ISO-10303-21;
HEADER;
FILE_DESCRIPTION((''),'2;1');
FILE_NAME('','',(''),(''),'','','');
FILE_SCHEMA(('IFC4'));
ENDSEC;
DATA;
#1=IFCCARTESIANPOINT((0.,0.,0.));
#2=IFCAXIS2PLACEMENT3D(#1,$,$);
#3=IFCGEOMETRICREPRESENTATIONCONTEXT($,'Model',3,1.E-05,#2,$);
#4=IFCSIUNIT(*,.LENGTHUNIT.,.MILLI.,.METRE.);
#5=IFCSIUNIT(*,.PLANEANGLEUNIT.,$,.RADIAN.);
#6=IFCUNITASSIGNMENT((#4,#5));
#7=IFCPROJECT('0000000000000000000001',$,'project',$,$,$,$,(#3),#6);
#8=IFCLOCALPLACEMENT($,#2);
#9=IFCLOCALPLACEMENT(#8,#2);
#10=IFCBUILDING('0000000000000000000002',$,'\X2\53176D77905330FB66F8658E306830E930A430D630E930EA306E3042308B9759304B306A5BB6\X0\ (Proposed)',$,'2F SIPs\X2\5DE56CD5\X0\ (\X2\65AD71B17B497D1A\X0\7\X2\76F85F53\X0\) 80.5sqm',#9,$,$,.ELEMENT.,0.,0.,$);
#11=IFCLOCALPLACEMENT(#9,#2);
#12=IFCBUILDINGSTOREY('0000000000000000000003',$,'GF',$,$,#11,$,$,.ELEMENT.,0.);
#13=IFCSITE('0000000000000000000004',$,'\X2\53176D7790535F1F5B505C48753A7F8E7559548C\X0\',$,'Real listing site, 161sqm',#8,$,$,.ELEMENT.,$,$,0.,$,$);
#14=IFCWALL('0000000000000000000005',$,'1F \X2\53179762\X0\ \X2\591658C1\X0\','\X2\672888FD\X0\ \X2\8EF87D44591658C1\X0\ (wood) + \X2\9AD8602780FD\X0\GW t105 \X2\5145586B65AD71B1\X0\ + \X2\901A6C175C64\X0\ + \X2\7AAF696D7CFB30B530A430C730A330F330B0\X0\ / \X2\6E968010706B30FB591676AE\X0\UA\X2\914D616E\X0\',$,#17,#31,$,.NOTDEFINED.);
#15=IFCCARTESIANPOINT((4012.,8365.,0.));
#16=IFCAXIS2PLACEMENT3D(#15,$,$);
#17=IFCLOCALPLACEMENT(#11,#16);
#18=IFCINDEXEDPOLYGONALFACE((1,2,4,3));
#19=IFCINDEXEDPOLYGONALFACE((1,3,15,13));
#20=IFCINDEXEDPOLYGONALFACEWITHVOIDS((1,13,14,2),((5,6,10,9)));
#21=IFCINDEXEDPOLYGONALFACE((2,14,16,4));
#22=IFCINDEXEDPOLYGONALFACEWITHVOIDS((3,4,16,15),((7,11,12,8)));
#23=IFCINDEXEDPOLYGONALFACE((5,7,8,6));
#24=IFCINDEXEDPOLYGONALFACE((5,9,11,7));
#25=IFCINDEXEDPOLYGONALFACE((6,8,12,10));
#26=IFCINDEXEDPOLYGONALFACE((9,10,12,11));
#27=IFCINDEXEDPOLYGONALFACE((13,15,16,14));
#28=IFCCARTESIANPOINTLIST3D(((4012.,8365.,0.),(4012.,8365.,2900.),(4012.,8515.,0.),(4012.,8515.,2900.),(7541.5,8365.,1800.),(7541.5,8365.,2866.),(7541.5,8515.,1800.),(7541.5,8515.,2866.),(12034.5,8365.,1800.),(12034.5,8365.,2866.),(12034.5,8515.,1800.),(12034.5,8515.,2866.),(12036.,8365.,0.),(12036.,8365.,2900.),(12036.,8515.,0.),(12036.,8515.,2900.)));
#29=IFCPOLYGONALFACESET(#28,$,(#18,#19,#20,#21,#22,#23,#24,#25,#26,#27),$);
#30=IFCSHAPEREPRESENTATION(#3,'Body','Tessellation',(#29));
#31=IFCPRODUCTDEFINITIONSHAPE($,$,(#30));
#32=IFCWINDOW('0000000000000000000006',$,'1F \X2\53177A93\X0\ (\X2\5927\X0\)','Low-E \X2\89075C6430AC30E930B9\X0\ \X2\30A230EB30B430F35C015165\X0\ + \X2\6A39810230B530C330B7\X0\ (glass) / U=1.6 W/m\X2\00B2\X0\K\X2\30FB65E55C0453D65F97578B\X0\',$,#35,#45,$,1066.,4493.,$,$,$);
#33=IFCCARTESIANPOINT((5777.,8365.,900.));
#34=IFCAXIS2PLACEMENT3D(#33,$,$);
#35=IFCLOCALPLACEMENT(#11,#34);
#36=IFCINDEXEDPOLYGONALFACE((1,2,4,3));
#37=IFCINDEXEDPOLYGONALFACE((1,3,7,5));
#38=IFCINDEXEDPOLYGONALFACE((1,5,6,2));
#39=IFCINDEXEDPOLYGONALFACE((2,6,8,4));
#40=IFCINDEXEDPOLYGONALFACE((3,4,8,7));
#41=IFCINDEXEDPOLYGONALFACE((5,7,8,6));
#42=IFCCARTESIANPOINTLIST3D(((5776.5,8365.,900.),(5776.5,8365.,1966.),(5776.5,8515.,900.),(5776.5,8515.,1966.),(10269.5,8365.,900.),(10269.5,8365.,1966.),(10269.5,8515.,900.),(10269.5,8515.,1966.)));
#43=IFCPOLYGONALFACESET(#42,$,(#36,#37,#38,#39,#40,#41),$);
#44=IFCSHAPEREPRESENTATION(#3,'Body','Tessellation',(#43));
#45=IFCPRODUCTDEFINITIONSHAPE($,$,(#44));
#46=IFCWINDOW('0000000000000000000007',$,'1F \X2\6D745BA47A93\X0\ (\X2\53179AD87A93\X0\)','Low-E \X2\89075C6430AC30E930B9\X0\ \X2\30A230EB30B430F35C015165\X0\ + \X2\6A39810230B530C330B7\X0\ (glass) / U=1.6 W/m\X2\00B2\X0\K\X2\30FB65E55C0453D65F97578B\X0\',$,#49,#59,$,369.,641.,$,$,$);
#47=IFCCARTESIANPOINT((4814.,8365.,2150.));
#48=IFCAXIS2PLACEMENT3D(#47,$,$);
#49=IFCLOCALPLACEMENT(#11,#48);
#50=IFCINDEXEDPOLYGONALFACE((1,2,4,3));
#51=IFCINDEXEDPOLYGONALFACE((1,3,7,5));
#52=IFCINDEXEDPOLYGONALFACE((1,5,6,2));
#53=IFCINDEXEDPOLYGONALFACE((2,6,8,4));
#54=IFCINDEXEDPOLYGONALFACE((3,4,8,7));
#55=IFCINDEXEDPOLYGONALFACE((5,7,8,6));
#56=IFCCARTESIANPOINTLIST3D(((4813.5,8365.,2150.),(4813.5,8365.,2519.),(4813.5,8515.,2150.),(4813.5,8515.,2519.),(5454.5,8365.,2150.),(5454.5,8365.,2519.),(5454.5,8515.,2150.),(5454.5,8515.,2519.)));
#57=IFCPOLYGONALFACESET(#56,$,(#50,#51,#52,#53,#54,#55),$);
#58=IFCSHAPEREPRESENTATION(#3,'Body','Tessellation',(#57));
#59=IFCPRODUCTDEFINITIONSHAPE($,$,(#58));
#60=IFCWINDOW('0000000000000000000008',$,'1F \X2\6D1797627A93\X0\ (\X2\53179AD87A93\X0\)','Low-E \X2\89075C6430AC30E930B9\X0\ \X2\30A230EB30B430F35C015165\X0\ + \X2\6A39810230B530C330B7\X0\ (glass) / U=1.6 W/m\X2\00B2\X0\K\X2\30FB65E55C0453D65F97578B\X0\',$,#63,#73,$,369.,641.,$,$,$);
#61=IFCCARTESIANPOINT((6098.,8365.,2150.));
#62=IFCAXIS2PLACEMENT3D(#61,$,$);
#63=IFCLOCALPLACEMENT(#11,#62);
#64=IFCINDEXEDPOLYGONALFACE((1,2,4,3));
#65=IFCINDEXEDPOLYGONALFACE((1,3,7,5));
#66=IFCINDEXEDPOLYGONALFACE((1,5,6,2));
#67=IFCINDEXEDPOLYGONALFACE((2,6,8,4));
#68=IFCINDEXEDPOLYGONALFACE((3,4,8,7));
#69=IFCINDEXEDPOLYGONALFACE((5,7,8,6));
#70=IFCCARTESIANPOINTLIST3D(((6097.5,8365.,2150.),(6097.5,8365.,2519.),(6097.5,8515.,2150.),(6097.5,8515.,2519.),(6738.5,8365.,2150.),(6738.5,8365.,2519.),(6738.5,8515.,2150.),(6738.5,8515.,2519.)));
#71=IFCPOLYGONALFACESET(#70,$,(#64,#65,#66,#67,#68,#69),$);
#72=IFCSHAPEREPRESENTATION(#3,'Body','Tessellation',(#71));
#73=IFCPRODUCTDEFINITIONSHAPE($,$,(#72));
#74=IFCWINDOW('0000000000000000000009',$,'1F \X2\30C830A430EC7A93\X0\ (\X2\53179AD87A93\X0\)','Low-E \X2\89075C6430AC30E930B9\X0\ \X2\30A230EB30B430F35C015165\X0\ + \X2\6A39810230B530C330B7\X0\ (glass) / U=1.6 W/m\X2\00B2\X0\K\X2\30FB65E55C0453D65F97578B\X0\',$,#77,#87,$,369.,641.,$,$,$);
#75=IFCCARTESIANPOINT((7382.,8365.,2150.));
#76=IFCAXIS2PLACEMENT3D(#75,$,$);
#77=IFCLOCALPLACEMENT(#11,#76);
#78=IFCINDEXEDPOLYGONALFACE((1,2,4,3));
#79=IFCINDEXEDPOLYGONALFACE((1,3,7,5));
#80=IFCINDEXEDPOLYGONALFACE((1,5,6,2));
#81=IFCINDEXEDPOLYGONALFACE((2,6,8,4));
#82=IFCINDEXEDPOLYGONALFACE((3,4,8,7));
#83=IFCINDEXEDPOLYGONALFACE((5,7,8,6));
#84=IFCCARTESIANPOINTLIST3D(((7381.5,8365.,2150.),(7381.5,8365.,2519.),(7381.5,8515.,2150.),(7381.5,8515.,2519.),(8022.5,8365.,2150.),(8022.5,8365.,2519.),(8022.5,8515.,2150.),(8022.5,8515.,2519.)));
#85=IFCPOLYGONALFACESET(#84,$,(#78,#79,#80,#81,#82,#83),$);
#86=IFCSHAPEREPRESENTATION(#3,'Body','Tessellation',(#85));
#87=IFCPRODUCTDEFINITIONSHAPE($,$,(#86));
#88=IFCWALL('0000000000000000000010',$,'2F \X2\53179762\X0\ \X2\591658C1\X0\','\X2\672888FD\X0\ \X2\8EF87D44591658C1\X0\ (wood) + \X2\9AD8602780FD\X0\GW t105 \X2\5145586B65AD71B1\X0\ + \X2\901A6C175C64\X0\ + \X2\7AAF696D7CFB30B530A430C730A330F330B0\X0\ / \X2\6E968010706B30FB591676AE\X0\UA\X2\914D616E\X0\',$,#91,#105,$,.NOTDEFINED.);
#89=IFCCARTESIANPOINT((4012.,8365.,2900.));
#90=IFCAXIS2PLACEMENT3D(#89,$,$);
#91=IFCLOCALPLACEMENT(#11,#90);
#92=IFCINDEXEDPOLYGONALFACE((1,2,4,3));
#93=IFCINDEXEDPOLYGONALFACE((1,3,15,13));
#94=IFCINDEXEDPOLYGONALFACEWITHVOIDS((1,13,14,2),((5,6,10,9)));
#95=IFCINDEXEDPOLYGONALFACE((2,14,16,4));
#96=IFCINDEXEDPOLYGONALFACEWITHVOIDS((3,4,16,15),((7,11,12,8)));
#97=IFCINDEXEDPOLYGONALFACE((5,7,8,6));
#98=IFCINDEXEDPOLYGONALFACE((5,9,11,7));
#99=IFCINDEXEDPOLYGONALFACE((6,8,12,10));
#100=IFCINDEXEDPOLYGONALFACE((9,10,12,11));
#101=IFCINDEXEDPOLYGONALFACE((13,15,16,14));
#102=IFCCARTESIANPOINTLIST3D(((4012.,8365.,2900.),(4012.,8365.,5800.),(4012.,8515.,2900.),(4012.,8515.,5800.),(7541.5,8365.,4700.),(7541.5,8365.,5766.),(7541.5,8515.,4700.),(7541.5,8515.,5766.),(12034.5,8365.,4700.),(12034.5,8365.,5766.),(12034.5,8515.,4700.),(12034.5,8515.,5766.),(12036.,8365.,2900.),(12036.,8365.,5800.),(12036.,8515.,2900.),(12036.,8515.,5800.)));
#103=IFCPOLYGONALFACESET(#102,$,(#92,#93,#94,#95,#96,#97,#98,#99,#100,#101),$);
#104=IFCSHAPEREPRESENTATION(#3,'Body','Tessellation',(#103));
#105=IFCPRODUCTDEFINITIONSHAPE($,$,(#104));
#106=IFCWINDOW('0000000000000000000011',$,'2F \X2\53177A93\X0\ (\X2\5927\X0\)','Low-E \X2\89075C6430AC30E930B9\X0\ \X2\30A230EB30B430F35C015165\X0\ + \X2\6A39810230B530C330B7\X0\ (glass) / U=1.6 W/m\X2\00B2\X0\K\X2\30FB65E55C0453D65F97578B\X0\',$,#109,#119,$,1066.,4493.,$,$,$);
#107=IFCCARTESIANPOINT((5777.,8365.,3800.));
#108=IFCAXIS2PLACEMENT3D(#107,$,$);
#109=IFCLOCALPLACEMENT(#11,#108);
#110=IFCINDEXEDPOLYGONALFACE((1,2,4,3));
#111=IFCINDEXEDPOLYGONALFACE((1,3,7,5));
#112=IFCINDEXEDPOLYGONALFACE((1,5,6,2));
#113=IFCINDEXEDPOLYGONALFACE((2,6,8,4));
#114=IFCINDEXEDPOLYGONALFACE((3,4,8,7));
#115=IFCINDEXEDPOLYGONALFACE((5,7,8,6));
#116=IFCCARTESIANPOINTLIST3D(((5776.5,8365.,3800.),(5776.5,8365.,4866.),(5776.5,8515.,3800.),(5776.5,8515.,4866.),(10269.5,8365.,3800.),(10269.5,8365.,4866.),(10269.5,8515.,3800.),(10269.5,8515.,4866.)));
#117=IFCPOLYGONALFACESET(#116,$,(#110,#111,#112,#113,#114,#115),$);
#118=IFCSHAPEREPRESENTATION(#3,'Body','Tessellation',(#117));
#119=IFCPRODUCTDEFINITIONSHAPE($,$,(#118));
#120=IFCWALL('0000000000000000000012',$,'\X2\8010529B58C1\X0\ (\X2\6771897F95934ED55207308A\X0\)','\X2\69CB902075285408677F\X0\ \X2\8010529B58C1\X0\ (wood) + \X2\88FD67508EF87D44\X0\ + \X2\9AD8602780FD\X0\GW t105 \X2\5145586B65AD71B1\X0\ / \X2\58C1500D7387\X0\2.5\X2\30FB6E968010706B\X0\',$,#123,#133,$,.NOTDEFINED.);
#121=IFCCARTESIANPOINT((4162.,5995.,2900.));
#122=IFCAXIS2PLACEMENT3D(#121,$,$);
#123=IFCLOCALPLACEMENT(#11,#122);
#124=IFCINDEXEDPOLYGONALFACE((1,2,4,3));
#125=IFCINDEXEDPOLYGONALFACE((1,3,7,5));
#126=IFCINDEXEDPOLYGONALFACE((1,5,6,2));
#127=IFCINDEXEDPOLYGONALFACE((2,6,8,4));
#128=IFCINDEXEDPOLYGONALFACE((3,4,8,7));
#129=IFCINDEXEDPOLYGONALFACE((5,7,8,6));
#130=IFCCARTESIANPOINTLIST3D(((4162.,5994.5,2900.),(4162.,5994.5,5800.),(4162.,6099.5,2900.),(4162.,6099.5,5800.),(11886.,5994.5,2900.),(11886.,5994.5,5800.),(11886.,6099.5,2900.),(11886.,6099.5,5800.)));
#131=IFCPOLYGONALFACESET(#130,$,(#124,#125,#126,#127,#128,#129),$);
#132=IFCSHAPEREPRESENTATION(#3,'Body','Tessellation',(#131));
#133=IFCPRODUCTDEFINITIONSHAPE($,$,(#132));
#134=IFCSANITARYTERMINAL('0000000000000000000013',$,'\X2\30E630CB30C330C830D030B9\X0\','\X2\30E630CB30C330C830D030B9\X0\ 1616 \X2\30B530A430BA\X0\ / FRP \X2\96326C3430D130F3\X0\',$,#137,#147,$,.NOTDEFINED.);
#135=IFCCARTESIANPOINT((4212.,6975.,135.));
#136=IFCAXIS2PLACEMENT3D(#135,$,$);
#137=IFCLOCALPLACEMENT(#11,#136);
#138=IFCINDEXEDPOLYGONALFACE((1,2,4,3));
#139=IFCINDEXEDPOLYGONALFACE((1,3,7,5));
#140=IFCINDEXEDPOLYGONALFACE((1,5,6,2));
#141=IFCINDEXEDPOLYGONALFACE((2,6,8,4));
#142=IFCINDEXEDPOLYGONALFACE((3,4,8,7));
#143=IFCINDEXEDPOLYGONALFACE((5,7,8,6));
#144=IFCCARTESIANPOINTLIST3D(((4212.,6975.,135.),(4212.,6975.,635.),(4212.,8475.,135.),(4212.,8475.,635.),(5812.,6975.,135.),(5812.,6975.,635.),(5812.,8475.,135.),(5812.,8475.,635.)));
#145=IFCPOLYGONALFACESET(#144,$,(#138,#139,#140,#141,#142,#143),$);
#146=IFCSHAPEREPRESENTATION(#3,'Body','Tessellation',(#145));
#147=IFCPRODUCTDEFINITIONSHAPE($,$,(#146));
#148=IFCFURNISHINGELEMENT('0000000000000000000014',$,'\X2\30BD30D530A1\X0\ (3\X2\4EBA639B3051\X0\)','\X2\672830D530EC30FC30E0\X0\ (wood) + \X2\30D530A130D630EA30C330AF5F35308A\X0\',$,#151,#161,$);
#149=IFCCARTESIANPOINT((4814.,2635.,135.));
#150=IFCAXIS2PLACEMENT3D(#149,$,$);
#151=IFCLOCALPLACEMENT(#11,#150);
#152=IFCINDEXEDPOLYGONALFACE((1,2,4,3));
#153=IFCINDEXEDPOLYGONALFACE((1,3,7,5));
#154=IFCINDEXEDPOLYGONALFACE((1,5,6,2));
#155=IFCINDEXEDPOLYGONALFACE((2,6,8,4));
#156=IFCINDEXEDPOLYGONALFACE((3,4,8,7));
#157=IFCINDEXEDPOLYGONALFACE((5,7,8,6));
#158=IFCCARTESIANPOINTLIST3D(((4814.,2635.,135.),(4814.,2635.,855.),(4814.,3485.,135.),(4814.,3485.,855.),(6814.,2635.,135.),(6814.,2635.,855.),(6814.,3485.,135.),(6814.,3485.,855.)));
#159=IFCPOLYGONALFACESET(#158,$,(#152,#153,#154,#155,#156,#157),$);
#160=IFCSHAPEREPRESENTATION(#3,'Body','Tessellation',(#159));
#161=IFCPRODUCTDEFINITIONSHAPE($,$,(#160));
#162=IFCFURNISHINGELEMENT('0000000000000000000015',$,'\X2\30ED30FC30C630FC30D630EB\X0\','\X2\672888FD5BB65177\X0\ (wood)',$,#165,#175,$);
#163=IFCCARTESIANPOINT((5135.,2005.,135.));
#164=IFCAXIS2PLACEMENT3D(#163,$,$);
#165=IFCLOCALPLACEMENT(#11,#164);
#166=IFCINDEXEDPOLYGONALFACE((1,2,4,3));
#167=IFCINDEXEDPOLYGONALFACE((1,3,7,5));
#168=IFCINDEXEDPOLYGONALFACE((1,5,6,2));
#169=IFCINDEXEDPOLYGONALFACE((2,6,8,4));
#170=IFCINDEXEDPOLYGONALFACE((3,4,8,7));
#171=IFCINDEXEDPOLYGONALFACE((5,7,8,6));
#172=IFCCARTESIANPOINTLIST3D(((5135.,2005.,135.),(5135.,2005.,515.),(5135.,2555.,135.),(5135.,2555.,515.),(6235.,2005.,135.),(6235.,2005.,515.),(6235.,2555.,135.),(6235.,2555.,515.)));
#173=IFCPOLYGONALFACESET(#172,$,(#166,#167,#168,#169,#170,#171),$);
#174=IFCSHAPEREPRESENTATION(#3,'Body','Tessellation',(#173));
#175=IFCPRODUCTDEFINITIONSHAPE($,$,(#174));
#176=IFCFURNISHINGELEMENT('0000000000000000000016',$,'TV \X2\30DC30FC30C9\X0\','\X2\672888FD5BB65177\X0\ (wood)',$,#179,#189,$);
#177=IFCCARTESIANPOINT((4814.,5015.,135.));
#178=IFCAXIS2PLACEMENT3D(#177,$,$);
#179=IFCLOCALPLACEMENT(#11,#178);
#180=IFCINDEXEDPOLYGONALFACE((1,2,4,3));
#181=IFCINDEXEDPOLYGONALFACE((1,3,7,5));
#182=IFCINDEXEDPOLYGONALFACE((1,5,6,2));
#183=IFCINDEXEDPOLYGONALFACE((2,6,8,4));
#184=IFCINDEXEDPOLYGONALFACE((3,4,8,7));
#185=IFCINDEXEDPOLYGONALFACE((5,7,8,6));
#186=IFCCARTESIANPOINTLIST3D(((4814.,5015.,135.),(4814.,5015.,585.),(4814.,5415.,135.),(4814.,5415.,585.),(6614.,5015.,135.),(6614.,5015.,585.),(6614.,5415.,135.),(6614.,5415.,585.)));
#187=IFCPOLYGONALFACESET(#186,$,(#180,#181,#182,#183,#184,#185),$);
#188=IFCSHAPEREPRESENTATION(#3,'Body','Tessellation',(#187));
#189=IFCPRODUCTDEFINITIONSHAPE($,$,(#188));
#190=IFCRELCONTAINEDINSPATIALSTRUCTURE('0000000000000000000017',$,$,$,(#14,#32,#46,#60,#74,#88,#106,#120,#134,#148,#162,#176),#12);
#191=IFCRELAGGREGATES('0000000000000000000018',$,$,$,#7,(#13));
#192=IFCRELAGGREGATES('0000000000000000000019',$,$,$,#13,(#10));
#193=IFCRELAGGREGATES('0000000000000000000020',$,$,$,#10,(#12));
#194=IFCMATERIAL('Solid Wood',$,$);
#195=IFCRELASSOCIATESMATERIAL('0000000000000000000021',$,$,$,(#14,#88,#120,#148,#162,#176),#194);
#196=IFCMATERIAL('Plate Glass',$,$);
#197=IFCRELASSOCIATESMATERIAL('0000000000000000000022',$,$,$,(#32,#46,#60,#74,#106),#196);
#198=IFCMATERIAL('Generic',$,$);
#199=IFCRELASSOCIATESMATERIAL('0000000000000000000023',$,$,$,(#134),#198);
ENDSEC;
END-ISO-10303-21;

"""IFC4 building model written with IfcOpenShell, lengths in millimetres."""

from ifc_helpers import new_model, si_unit, frame, frame_2d, origin, place, context, project, spatial, rectangle, extrude, material, element, fill, save


model = new_model("IFC4")

# Units and contexts
model_context = context("Model", 3, precision=1e-05, world=origin())
ifc_project = project(units=[si_unit("LENGTHUNIT", "METRE", prefix="MILLI"), si_unit("PLANEANGLEUNIT", "RADIAN")], contexts=[model_context])

# Site, building, storey
site_placement = place(None, origin())
site = spatial("IfcSite", under=ifc_project, at=site_placement, Name="北海道弟子屈町美留和", ObjectType="Real listing site, 161sqm", CompositionType="ELEMENT", RefElevation=0.0)
building_placement = place(site_placement, origin())
building = spatial("IfcBuilding", under=site, at=building_placement, Name="北海道・書斎とライブラリのある静かな家 (Proposed)", ObjectType="2F SIPs工法 (断熱等級7相当) 80.5sqm", CompositionType="ELEMENT", ElevationOfRefHeight=0.0, ElevationOfTerrain=0.0)
storey_placement = place(building_placement, origin())
storey = spatial("IfcBuildingStorey", under=building, at=storey_placement, Name="GF", CompositionType="ELEMENT", Elevation=0.0)

# Wall, openings, windows
ifc_material_1 = material(Name="Solid Wood")
wall_1_placement = place(storey_placement, frame((4012.0, 8365.0, 0.0)))
wall_1 = element("IfcWall", 1, at=wall_1_placement, inside=storey, material=ifc_material_1, Name="1F 北面 外壁", Description="木製 軸組外壁 (wood) + 高性能GW t105 充填断熱 + 通気層 + 窯業系サイディング / 準耐火・外皮UA配慮", PredefinedType="NOTDEFINED", context=model_context, shape_type="SweptSolid", body=[
    extrude(rectangle(XDim=8024.0, YDim=150.0, at=frame_2d((4012.0, 75.0))), frame((4012.0, 8365.0, 0.0)), (0.0, 0.0, 1.0), 2900.0),
])
opening_1_placement = place(storey_placement, frame((5777.0, 8365.0, 900.0)))
opening_1 = element("IfcOpeningElement", 2, at=opening_1_placement, cuts=wall_1, PredefinedType="NOTDEFINED", context=model_context, shape_type="SweptSolid", body=[
    extrude(rectangle(XDim=4493.0, YDim=150.0, at=frame_2d((2246.0, 75.0))), frame((5777.0, 8365.0, 900.0)), (0.0, 0.0, 1.0), 1066.0),
])
opening_2_placement = place(storey_placement, frame((4814.0, 8365.0, 2150.0)))
opening_2 = element("IfcOpeningElement", 3, at=opening_2_placement, cuts=wall_1, PredefinedType="NOTDEFINED", context=model_context, shape_type="SweptSolid", body=[
    extrude(rectangle(XDim=641.0, YDim=150.0, at=frame_2d((320.0, 75.0))), frame((4814.0, 8365.0, 2150.0)), (0.0, 0.0, 1.0), 369.0),
])
opening_3_placement = place(storey_placement, frame((6098.0, 8365.0, 2150.0)))
opening_3 = element("IfcOpeningElement", 4, at=opening_3_placement, cuts=wall_1, PredefinedType="NOTDEFINED", context=model_context, shape_type="SweptSolid", body=[
    extrude(rectangle(XDim=641.0, YDim=150.0, at=frame_2d((320.0, 75.0))), frame((6098.0, 8365.0, 2150.0)), (0.0, 0.0, 1.0), 369.0),
])
opening_4_placement = place(storey_placement, frame((7382.0, 8365.0, 2150.0)))
opening_4 = element("IfcOpeningElement", 5, at=opening_4_placement, cuts=wall_1, PredefinedType="NOTDEFINED", context=model_context, shape_type="SweptSolid", body=[
    extrude(rectangle(XDim=641.0, YDim=150.0, at=frame_2d((320.0, 75.0))), frame((7382.0, 8365.0, 2150.0)), (0.0, 0.0, 1.0), 369.0),
])
ifc_material_2 = material(Name="Plate Glass")
window_1_placement = place(storey_placement, frame((5777.0, 8365.0, 900.0)))
window_1 = element("IfcWindow", 6, at=window_1_placement, inside=storey, material=ifc_material_2, Name="1F 北窓 (大)", Description="Low-E 複層ガラス アルゴン封入 + 樹脂サッシ (glass) / U=1.6 W/m²K・日射取得型", OverallHeight=1066.0, OverallWidth=4493.0, context=model_context, shape_type="SweptSolid", body=[
    extrude(rectangle(XDim=4493.0, YDim=150.0, at=frame_2d((2246.0, 75.0))), frame((5777.0, 8365.0, 900.0)), (0.0, 0.0, 1.0), 1066.0),
])
fill(opening_1, window_1)
window_2_placement = place(storey_placement, frame((4814.0, 8365.0, 2150.0)))
window_2 = element("IfcWindow", 7, at=window_2_placement, inside=storey, material=ifc_material_2, Name="1F 浴室窓 (北高窓)", Description="Low-E 複層ガラス アルゴン封入 + 樹脂サッシ (glass) / U=1.6 W/m²K・日射取得型", OverallHeight=369.0, OverallWidth=641.0, context=model_context, shape_type="SweptSolid", body=[
    extrude(rectangle(XDim=641.0, YDim=150.0, at=frame_2d((320.0, 75.0))), frame((4814.0, 8365.0, 2150.0)), (0.0, 0.0, 1.0), 369.0),
])
fill(opening_2, window_2)
window_3_placement = place(storey_placement, frame((6098.0, 8365.0, 2150.0)))
window_3 = element("IfcWindow", 8, at=window_3_placement, inside=storey, material=ifc_material_2, Name="1F 洗面窓 (北高窓)", Description="Low-E 複層ガラス アルゴン封入 + 樹脂サッシ (glass) / U=1.6 W/m²K・日射取得型", OverallHeight=369.0, OverallWidth=641.0, context=model_context, shape_type="SweptSolid", body=[
    extrude(rectangle(XDim=641.0, YDim=150.0, at=frame_2d((320.0, 75.0))), frame((6098.0, 8365.0, 2150.0)), (0.0, 0.0, 1.0), 369.0),
])
fill(opening_3, window_3)
window_4_placement = place(storey_placement, frame((7382.0, 8365.0, 2150.0)))
window_4 = element("IfcWindow", 9, at=window_4_placement, inside=storey, material=ifc_material_2, Name="1F トイレ窓 (北高窓)", Description="Low-E 複層ガラス アルゴン封入 + 樹脂サッシ (glass) / U=1.6 W/m²K・日射取得型", OverallHeight=369.0, OverallWidth=641.0, context=model_context, shape_type="SweptSolid", body=[
    extrude(rectangle(XDim=641.0, YDim=150.0, at=frame_2d((320.0, 75.0))), frame((7382.0, 8365.0, 2150.0)), (0.0, 0.0, 1.0), 369.0),
])
fill(opening_4, window_4)

# Wall, opening, window
wall_2_placement = place(storey_placement, frame((4012.0, 8365.0, 2900.0)))
wall_2 = element("IfcWall", 10, at=wall_2_placement, inside=storey, material=ifc_material_1, Name="2F 北面 外壁", Description="木製 軸組外壁 (wood) + 高性能GW t105 充填断熱 + 通気層 + 窯業系サイディング / 準耐火・外皮UA配慮", PredefinedType="NOTDEFINED", context=model_context, shape_type="SweptSolid", body=[
    extrude(rectangle(XDim=8024.0, YDim=150.0, at=frame_2d((4012.0, 75.0))), frame((4012.0, 8365.0, 2900.0)), (0.0, 0.0, 1.0), 2900.0),
])
opening_5_placement = place(storey_placement, frame((5777.0, 8365.0, 3800.0)))
opening_5 = element("IfcOpeningElement", 11, at=opening_5_placement, cuts=wall_2, PredefinedType="NOTDEFINED", context=model_context, shape_type="SweptSolid", body=[
    extrude(rectangle(XDim=4493.0, YDim=150.0, at=frame_2d((2246.0, 75.0))), frame((5777.0, 8365.0, 3800.0)), (0.0, 0.0, 1.0), 1066.0),
])
window_5_placement = place(storey_placement, frame((5777.0, 8365.0, 3800.0)))
window_5 = element("IfcWindow", 12, at=window_5_placement, inside=storey, material=ifc_material_2, Name="2F 北窓 (大)", Description="Low-E 複層ガラス アルゴン封入 + 樹脂サッシ (glass) / U=1.6 W/m²K・日射取得型", OverallHeight=1066.0, OverallWidth=4493.0, context=model_context, shape_type="SweptSolid", body=[
    extrude(rectangle(XDim=4493.0, YDim=150.0, at=frame_2d((2246.0, 75.0))), frame((5777.0, 8365.0, 3800.0)), (0.0, 0.0, 1.0), 1066.0),
])
fill(opening_5, window_5)

# Wall
wall_3_placement = place(storey_placement, frame((4162.0, 5995.0, 2900.0)))
element("IfcWall", 13, at=wall_3_placement, inside=storey, material=ifc_material_1, Name="耐力壁 (東西間仕切り)", Description="構造用合板 耐力壁 (wood) + 製材軸組 + 高性能GW t105 充填断熱 / 壁倍率2.5・準耐火", PredefinedType="NOTDEFINED", context=model_context, shape_type="SweptSolid", body=[
    extrude(rectangle(XDim=7724.0, YDim=105.0, at=frame_2d((3862.0, 52.0))), frame((4162.0, 5995.0, 2900.0)), (0.0, 0.0, 1.0), 2900.0),
])

# Sanitary terminal
ifc_material_3 = material(Name="Generic")
sanitary_terminal_placement = place(storey_placement, frame((4212.0, 6975.0, 135.0)))
element("IfcSanitaryTerminal", 14, at=sanitary_terminal_placement, inside=storey, material=ifc_material_3, Name="ユニットバス", Description="ユニットバス 1616 サイズ / FRP 防水パン", PredefinedType="NOTDEFINED", context=model_context, shape_type="SweptSolid", body=[
    extrude(rectangle(XDim=1600.0, YDim=1500.0, at=frame_2d((800.0, 750.0))), frame((4212.0, 6975.0, 135.0)), (0.0, 0.0, 1.0), 500.0),
])

# Furnishing elements
furnishing_1_placement = place(storey_placement, frame((4814.0, 2635.0, 135.0)))
element("IfcFurnishingElement", 15, at=furnishing_1_placement, inside=storey, material=ifc_material_1, Name="ソファ (3人掛け)", Description="木フレーム (wood) + ファブリック張り", context=model_context, shape_type="SweptSolid", body=[
    extrude(rectangle(XDim=2000.0, YDim=850.0, at=frame_2d((1000.0, 425.0))), frame((4814.0, 2635.0, 135.0)), (0.0, 0.0, 1.0), 720.0),
])
furnishing_2_placement = place(storey_placement, frame((5135.0, 2005.0, 135.0)))
element("IfcFurnishingElement", 16, at=furnishing_2_placement, inside=storey, material=ifc_material_1, Name="ローテーブル", Description="木製家具 (wood)", context=model_context, shape_type="SweptSolid", body=[
    extrude(rectangle(XDim=1100.0, YDim=550.0, at=frame_2d((550.0, 275.0))), frame((5135.0, 2005.0, 135.0)), (0.0, 0.0, 1.0), 380.0),
])
furnishing_3_placement = place(storey_placement, frame((4814.0, 5015.0, 135.0)))
element("IfcFurnishingElement", 17, at=furnishing_3_placement, inside=storey, material=ifc_material_1, Name="TV ボード", Description="木製家具 (wood)", context=model_context, shape_type="SweptSolid", body=[
    extrude(rectangle(XDim=1800.0, YDim=400.0, at=frame_2d((900.0, 200.0))), frame((4814.0, 5015.0, 135.0)), (0.0, 0.0, 1.0), 450.0),
])

save(model, "model.ifc")
